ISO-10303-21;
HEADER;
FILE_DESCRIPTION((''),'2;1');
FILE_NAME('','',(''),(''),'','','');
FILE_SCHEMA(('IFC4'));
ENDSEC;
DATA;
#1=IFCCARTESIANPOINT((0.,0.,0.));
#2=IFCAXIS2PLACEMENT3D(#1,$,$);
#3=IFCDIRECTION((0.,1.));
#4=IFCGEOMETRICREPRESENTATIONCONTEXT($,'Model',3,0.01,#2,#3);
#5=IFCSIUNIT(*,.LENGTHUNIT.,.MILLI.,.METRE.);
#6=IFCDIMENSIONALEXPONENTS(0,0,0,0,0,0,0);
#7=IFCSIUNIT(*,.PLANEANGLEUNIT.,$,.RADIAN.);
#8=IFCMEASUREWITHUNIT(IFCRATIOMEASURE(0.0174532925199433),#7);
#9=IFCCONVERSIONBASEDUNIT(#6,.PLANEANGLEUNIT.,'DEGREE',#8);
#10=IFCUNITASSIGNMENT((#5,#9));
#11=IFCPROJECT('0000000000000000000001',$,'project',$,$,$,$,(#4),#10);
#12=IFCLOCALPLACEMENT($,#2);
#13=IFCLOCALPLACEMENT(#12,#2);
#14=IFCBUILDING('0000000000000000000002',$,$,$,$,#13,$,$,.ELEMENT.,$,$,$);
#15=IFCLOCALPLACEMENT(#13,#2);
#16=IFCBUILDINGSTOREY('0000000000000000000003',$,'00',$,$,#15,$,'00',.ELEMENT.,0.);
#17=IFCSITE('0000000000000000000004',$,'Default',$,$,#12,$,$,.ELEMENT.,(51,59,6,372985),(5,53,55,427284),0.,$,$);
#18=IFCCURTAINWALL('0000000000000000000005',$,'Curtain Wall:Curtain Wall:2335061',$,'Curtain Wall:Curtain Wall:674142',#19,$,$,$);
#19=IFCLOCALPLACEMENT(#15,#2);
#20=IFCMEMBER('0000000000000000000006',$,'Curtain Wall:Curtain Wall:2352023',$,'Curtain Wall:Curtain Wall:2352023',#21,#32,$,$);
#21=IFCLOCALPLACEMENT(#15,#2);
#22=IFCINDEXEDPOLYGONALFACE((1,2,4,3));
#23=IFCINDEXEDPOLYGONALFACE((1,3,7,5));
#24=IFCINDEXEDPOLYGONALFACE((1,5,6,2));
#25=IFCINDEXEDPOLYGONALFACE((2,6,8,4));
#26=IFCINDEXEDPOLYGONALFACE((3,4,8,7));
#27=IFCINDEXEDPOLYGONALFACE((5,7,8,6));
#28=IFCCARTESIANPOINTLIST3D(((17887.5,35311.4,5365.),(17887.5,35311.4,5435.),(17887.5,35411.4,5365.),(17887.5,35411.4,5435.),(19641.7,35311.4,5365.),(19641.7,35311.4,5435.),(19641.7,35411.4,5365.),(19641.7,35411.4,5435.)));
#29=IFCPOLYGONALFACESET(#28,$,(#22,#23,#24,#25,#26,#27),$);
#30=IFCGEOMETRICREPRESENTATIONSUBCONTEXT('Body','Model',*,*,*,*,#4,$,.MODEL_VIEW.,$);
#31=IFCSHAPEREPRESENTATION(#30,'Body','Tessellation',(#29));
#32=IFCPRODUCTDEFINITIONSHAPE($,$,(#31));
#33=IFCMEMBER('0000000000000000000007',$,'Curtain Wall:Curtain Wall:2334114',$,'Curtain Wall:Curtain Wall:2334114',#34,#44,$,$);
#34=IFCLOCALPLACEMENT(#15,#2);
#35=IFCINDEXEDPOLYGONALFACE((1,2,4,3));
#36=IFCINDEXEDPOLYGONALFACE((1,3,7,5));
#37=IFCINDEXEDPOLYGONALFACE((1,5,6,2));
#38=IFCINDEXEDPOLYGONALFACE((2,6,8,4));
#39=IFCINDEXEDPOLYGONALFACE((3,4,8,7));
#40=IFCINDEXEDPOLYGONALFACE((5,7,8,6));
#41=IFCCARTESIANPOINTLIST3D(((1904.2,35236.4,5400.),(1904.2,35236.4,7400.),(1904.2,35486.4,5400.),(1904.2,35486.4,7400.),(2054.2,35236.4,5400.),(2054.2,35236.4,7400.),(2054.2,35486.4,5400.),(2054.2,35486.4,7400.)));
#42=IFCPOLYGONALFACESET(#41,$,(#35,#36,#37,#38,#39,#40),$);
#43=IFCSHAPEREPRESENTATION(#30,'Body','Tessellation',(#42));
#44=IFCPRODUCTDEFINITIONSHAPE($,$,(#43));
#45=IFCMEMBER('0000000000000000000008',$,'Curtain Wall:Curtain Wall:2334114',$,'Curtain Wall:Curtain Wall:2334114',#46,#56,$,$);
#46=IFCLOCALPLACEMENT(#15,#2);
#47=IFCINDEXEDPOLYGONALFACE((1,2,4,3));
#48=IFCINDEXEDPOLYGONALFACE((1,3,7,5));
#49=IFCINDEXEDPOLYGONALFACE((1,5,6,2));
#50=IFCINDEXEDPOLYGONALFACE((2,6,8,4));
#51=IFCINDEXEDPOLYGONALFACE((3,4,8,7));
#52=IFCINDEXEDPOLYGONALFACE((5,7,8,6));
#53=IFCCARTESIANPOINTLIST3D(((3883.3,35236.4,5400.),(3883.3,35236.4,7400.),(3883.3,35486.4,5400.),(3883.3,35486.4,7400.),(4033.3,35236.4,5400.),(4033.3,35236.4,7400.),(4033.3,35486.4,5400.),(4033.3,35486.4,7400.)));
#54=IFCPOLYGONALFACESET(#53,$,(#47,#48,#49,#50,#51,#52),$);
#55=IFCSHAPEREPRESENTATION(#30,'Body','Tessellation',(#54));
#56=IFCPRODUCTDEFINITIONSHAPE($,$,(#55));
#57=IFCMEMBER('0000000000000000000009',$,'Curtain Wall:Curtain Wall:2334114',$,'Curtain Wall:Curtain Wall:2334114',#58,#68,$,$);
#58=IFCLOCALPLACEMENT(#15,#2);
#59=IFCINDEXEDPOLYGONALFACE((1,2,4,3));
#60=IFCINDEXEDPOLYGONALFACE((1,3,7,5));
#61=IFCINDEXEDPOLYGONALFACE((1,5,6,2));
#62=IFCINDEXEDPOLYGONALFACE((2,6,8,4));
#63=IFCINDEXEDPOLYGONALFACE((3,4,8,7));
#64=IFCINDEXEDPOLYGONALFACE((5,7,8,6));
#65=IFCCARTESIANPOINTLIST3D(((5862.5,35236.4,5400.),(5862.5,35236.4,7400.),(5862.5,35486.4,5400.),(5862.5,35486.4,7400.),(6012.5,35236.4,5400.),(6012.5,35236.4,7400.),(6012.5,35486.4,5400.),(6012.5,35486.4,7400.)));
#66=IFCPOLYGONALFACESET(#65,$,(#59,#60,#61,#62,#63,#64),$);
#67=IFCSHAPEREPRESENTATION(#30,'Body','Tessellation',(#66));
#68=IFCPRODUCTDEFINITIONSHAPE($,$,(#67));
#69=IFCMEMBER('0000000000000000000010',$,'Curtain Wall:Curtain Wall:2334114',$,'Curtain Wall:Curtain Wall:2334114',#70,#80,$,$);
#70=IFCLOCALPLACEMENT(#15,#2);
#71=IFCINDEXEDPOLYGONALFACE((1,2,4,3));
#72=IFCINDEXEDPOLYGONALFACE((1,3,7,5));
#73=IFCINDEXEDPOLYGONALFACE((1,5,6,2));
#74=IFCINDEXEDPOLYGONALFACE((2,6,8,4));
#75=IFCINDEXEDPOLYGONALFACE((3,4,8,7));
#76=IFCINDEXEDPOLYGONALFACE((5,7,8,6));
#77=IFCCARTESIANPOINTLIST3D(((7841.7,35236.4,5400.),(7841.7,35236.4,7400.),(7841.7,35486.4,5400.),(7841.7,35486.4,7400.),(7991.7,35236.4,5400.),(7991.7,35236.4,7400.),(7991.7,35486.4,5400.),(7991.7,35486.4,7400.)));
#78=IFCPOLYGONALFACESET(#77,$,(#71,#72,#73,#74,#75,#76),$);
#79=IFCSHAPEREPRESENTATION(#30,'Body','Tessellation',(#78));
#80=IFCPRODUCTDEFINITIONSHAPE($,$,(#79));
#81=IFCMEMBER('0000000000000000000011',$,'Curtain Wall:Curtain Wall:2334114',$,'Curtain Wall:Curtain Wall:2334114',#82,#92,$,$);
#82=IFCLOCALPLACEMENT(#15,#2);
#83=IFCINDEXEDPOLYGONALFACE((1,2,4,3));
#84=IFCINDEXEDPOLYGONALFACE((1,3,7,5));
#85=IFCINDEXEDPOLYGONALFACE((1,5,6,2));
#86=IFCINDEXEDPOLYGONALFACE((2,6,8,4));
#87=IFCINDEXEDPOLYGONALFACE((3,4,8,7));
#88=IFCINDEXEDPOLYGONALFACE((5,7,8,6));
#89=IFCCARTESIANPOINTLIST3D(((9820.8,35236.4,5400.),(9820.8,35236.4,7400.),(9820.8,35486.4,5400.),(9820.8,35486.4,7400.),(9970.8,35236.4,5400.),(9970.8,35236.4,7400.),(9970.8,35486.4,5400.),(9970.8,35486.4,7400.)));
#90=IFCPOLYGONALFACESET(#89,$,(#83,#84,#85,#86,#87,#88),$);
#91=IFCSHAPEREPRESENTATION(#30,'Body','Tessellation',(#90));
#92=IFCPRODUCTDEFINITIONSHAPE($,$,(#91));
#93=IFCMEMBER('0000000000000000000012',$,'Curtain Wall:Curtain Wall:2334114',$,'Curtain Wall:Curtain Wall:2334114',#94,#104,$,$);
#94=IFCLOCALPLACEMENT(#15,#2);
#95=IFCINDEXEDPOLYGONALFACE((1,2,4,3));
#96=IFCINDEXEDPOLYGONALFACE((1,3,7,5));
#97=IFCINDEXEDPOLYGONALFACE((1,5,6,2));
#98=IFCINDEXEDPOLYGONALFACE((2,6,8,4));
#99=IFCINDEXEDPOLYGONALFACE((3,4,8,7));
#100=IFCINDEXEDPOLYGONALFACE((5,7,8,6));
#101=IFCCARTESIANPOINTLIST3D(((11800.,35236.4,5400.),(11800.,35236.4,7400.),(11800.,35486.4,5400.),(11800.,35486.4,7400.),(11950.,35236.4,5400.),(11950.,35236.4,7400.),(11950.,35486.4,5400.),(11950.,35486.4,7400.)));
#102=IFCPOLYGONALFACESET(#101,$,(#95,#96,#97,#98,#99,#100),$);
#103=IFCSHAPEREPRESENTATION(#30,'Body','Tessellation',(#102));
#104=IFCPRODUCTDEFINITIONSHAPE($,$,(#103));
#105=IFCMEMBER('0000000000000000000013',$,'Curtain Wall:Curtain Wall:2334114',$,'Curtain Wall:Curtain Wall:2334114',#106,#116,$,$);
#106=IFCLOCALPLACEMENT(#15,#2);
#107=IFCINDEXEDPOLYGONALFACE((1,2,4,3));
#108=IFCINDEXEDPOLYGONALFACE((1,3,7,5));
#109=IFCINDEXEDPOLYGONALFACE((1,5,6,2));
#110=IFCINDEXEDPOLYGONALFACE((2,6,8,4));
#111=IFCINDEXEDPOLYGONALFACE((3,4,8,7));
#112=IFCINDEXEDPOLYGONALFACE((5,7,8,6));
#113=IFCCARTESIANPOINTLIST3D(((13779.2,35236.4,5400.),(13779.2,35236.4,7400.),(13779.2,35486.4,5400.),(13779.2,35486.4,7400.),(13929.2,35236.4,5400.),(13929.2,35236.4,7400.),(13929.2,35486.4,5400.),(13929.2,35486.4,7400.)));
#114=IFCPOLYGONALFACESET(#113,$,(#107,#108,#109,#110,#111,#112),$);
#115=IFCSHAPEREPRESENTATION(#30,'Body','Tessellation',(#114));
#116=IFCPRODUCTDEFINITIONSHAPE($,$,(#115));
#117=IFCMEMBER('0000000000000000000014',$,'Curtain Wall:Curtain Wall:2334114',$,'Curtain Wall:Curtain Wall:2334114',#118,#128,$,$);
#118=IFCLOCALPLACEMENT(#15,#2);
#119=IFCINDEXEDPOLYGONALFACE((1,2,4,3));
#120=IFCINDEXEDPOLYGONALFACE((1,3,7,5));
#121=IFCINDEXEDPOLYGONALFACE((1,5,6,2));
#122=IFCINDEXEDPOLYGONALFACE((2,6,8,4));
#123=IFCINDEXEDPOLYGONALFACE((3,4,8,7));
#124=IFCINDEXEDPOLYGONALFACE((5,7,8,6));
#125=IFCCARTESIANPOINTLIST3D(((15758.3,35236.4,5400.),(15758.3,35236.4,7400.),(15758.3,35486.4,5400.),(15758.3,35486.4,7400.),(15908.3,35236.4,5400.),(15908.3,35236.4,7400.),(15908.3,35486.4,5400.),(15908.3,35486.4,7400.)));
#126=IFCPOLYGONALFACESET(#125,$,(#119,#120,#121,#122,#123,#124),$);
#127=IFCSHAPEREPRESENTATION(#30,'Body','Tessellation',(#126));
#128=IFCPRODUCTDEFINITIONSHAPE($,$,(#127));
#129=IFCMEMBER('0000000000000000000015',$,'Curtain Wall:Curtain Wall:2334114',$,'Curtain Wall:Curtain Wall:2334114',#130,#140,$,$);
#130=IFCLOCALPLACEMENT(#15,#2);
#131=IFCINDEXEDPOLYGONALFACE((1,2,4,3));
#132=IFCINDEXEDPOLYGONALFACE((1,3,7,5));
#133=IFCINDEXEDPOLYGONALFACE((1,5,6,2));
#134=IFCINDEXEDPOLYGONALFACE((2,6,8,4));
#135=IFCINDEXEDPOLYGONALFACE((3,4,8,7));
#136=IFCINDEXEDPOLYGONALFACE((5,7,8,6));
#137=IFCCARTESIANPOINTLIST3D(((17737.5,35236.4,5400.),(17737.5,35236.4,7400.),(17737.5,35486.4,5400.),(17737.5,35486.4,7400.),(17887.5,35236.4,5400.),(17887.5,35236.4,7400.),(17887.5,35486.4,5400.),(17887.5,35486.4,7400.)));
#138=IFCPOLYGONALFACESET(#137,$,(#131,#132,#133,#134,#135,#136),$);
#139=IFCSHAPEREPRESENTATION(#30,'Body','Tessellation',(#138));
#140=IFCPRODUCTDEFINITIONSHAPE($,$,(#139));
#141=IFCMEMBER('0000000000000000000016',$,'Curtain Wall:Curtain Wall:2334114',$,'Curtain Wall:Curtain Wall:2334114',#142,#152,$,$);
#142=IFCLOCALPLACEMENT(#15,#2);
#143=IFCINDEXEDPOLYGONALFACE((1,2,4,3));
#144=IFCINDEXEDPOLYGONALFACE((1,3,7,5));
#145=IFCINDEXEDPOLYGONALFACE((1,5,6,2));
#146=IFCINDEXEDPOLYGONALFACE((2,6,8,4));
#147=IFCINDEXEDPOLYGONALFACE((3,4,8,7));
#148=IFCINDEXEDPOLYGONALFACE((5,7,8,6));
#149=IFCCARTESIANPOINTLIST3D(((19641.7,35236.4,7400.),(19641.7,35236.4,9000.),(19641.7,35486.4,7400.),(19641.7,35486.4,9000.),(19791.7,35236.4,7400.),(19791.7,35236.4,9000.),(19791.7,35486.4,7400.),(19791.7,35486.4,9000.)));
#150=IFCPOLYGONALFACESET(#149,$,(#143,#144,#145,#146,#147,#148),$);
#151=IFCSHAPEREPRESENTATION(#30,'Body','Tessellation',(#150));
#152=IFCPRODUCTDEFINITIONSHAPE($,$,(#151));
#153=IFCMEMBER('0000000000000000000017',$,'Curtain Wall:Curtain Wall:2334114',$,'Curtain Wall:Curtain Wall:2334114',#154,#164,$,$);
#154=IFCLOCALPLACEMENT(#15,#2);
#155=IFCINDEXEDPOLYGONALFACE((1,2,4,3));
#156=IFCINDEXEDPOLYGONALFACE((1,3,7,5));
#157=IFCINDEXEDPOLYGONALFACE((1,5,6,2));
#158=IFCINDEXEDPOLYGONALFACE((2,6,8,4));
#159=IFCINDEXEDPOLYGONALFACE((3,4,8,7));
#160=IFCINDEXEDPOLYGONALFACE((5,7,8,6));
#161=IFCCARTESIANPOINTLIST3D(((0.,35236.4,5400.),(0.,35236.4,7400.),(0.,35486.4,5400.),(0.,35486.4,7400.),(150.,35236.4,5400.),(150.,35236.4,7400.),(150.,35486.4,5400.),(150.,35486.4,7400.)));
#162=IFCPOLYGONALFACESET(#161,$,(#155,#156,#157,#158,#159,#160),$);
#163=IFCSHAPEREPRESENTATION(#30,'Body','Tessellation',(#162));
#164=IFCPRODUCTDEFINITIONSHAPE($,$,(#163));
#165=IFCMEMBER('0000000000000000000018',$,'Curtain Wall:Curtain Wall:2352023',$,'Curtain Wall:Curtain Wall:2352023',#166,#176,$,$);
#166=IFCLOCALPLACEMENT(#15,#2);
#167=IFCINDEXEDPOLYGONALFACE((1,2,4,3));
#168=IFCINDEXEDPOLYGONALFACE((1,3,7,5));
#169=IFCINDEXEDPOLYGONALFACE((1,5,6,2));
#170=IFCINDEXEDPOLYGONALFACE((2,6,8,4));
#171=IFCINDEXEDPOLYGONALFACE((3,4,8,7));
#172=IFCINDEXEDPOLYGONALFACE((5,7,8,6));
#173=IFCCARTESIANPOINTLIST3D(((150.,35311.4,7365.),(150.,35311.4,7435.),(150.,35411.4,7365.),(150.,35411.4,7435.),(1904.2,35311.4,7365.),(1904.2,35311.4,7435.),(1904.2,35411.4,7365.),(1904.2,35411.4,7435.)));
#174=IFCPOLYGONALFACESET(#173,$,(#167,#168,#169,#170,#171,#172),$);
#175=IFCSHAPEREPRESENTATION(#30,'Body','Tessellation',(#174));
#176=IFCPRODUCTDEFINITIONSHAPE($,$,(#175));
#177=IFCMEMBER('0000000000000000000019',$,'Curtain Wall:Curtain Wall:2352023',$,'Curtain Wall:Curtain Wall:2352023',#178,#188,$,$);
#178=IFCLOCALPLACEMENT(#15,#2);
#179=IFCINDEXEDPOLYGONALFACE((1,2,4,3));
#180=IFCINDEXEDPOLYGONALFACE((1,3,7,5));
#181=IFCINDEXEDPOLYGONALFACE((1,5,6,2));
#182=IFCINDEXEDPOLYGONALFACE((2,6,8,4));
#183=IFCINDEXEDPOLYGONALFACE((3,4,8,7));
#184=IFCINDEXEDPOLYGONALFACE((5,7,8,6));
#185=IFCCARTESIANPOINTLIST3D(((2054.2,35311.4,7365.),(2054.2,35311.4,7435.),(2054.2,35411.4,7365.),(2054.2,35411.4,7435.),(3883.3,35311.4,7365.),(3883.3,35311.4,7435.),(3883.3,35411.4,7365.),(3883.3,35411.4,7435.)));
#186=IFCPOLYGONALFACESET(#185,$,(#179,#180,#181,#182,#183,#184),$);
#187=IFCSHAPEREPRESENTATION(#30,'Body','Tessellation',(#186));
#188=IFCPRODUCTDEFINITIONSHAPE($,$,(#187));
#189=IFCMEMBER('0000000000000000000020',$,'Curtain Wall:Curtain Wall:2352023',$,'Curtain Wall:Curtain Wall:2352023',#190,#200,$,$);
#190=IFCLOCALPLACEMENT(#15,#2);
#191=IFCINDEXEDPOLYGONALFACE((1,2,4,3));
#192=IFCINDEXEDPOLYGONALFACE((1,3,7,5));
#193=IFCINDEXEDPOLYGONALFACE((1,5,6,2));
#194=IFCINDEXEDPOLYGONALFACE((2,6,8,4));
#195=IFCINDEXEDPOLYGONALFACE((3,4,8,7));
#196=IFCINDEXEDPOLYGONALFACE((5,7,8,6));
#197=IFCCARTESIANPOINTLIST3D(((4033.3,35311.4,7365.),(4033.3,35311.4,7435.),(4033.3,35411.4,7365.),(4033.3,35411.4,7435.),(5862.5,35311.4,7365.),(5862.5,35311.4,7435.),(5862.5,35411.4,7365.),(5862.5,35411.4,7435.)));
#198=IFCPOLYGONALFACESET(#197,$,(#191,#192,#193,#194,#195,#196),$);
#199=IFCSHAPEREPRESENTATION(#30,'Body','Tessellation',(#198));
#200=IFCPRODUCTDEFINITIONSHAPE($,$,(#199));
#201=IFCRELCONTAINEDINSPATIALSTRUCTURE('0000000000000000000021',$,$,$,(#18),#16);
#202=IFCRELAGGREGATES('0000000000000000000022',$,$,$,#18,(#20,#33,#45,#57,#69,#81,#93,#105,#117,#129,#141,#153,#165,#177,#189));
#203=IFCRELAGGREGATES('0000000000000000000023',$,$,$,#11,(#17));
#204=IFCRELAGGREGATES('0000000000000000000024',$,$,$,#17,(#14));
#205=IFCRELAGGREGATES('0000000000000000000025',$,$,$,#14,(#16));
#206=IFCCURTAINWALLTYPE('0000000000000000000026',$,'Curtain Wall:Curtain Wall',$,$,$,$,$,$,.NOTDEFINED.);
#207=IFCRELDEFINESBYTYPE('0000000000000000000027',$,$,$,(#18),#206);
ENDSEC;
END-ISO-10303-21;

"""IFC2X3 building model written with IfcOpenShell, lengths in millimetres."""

from ifc_helpers import new_model, entity, si_unit, converted_unit, direction, frame, frame_2d, origin, place, context, subcontext, project, spatial, rectangle, extrude, type_object, element, aggregate, save


model = new_model("IFC2X3")

# Units and contexts
model_context = context("Model", 3, precision=0.01, world=origin(), true_north=direction((0.0, 1.0)))
body_context = subcontext(model_context, "Body", "Model", "MODEL_VIEW")
ifc_project = project(units=[si_unit("LENGTHUNIT", "METRE", prefix="MILLI"), converted_unit("PLANEANGLEUNIT", "DEGREE", entity("IfcRatioMeasure", 0.0174532925199433), si_unit("PLANEANGLEUNIT", "RADIAN"), dimensions=[0, 0, 0, 0, 0, 0, 0])], contexts=[model_context])

# Site, building, storey
site_placement = place(None, origin())
site = spatial("IfcSite", under=ifc_project, at=site_placement, Name="Default", CompositionType="ELEMENT", RefLatitude=(51, 59, 6, 372985), RefLongitude=(5, 53, 55, 427284), RefElevation=0.0)
building_placement = place(site_placement, origin())
building = spatial("IfcBuilding", under=site, at=building_placement, CompositionType="ELEMENT")
storey_placement = place(building_placement, origin())
storey = spatial("IfcBuildingStorey", under=building, at=storey_placement, Name="00", LongName="00", CompositionType="ELEMENT", Elevation=0.0)

# Curtain wall, members
curtain_wall_type = type_object("IfcCurtainWallType", Name="Curtain Wall:Curtain Wall", PredefinedType="NOTDEFINED")
curtain_wall_placement = place(storey_placement, origin())
curtain_wall = element("IfcCurtainWall", 1, at=curtain_wall_placement, inside=storey, type_object=curtain_wall_type, Name="Curtain Wall:Curtain Wall:2335061", ObjectType="Curtain Wall:Curtain Wall:674142")
member_1_placement = place(curtain_wall_placement, origin())
member_1 = element("IfcMember", 2, at=member_1_placement, Name="Curtain Wall:Curtain Wall:2352023", ObjectType="Curtain Wall:Curtain Wall:2352023", context=body_context, shape_type="SweptSolid", body=[
    extrude(rectangle(XDim=70.0, YDim=100.0, at=frame_2d((0.0, 0.0), x_axis=(1.0, 0.0))), frame((19641.7, 35361.4, 5400.0), z_axis=(-1.0, 0.0, 0.0), x_axis=(0.0, 0.0, -1.0)), (0.0, 0.0, 1.0), 1754.2),
])
member_2_placement = place(curtain_wall_placement, origin())
member_2 = element("IfcMember", 3, at=member_2_placement, Name="Curtain Wall:Curtain Wall:2334114", ObjectType="Curtain Wall:Curtain Wall:2334114", context=body_context, shape_type="SweptSolid", body=[
    extrude(rectangle(XDim=150.0, YDim=250.0, at=frame_2d((0.0, 0.0), x_axis=(1.0, 0.0))), frame((1979.2, 35361.4, 5400.0), z_axis=(0.0, 0.0, 1.0), x_axis=(-1.0, 0.0, 0.0)), (0.0, 0.0, 1.0), 2000.0),
])
member_3_placement = place(curtain_wall_placement, origin())
member_3 = element("IfcMember", 4, at=member_3_placement, Name="Curtain Wall:Curtain Wall:2334114", ObjectType="Curtain Wall:Curtain Wall:2334114", context=body_context, shape_type="SweptSolid", body=[
    extrude(rectangle(XDim=150.0, YDim=250.0, at=frame_2d((0.0, 0.0), x_axis=(1.0, 0.0))), frame((3958.3, 35361.4, 5400.0), z_axis=(0.0, 0.0, 1.0), x_axis=(-1.0, 0.0, 0.0)), (0.0, 0.0, 1.0), 2000.0),
])
member_4_placement = place(curtain_wall_placement, origin())
member_4 = element("IfcMember", 5, at=member_4_placement, Name="Curtain Wall:Curtain Wall:2334114", ObjectType="Curtain Wall:Curtain Wall:2334114", context=body_context, shape_type="SweptSolid", body=[
    extrude(rectangle(XDim=150.0, YDim=250.0, at=frame_2d((0.0, 0.0), x_axis=(1.0, 0.0))), frame((5937.5, 35361.4, 5400.0), z_axis=(0.0, 0.0, 1.0), x_axis=(-1.0, 0.0, 0.0)), (0.0, 0.0, 1.0), 2000.0),
])
member_5_placement = place(curtain_wall_placement, origin())
member_5 = element("IfcMember", 6, at=member_5_placement, Name="Curtain Wall:Curtain Wall:2334114", ObjectType="Curtain Wall:Curtain Wall:2334114", context=body_context, shape_type="SweptSolid", body=[
    extrude(rectangle(XDim=150.0, YDim=250.0, at=frame_2d((0.0, 0.0), x_axis=(1.0, 0.0))), frame((7916.7, 35361.4, 5400.0), z_axis=(0.0, 0.0, 1.0), x_axis=(-1.0, 0.0, 0.0)), (0.0, 0.0, 1.0), 2000.0),
])
member_6_placement = place(curtain_wall_placement, origin())
member_6 = element("IfcMember", 7, at=member_6_placement, Name="Curtain Wall:Curtain Wall:2334114", ObjectType="Curtain Wall:Curtain Wall:2334114", context=body_context, shape_type="SweptSolid", body=[
    extrude(rectangle(XDim=150.0, YDim=250.0, at=frame_2d((0.0, 0.0), x_axis=(1.0, 0.0))), frame((9895.8, 35361.4, 5400.0), z_axis=(0.0, 0.0, 1.0), x_axis=(-1.0, 0.0, 0.0)), (0.0, 0.0, 1.0), 2000.0),
])
member_7_placement = place(curtain_wall_placement, origin())
member_7 = element("IfcMember", 8, at=member_7_placement, Name="Curtain Wall:Curtain Wall:2334114", ObjectType="Curtain Wall:Curtain Wall:2334114", context=body_context, shape_type="SweptSolid", body=[
    extrude(rectangle(XDim=150.0, YDim=250.0, at=frame_2d((0.0, 0.0), x_axis=(1.0, 0.0))), frame((11875.0, 35361.4, 5400.0), z_axis=(0.0, 0.0, 1.0), x_axis=(-1.0, 0.0, 0.0)), (0.0, 0.0, 1.0), 2000.0),
])
member_8_placement = place(curtain_wall_placement, origin())
member_8 = element("IfcMember", 9, at=member_8_placement, Name="Curtain Wall:Curtain Wall:2334114", ObjectType="Curtain Wall:Curtain Wall:2334114", context=body_context, shape_type="SweptSolid", body=[
    extrude(rectangle(XDim=150.0, YDim=250.0, at=frame_2d((0.0, 0.0), x_axis=(1.0, 0.0))), frame((13854.2, 35361.4, 5400.0), z_axis=(0.0, 0.0, 1.0), x_axis=(-1.0, 0.0, 0.0)), (0.0, 0.0, 1.0), 2000.0),
])
member_9_placement = place(curtain_wall_placement, origin())
member_9 = element("IfcMember", 10, at=member_9_placement, Name="Curtain Wall:Curtain Wall:2334114", ObjectType="Curtain Wall:Curtain Wall:2334114", context=body_context, shape_type="SweptSolid", body=[
    extrude(rectangle(XDim=150.0, YDim=250.0, at=frame_2d((0.0, 0.0), x_axis=(1.0, 0.0))), frame((15833.3, 35361.4, 5400.0), z_axis=(0.0, 0.0, 1.0), x_axis=(-1.0, 0.0, 0.0)), (0.0, 0.0, 1.0), 2000.0),
])
member_10_placement = place(curtain_wall_placement, origin())
member_10 = element("IfcMember", 11, at=member_10_placement, Name="Curtain Wall:Curtain Wall:2334114", ObjectType="Curtain Wall:Curtain Wall:2334114", context=body_context, shape_type="SweptSolid", body=[
    extrude(rectangle(XDim=150.0, YDim=250.0, at=frame_2d((0.0, 0.0), x_axis=(1.0, 0.0))), frame((17812.5, 35361.4, 5400.0), z_axis=(0.0, 0.0, 1.0), x_axis=(-1.0, 0.0, 0.0)), (0.0, 0.0, 1.0), 2000.0),
])
member_11_placement = place(curtain_wall_placement, origin())
member_11 = element("IfcMember", 12, at=member_11_placement, Name="Curtain Wall:Curtain Wall:2334114", ObjectType="Curtain Wall:Curtain Wall:2334114", context=body_context, shape_type="SweptSolid", body=[
    extrude(rectangle(XDim=150.0, YDim=250.0, at=frame_2d((0.0, 0.0), x_axis=(1.0, 0.0))), frame((19716.7, 35361.4, 7400.0), z_axis=(0.0, 0.0, 1.0), x_axis=(-1.0, 0.0, 0.0)), (0.0, 0.0, 1.0), 1600.0),
])
member_12_placement = place(curtain_wall_placement, origin())
member_12 = element("IfcMember", 13, at=member_12_placement, Name="Curtain Wall:Curtain Wall:2334114", ObjectType="Curtain Wall:Curtain Wall:2334114", context=body_context, shape_type="SweptSolid", body=[
    extrude(rectangle(XDim=150.0, YDim=250.0, at=frame_2d((0.0, 0.0), x_axis=(1.0, 0.0))), frame((75.0, 35361.4, 7400.0), z_axis=(0.0, 0.0, -1.0), x_axis=(-1.0, 0.0, 0.0)), (0.0, 0.0, 1.0), 2000.0),
])
member_13_placement = place(curtain_wall_placement, origin())
member_13 = element("IfcMember", 14, at=member_13_placement, Name="Curtain Wall:Curtain Wall:2352023", ObjectType="Curtain Wall:Curtain Wall:2352023", context=body_context, shape_type="SweptSolid", body=[
    extrude(rectangle(XDim=70.0, YDim=100.0, at=frame_2d((0.0, 0.0), x_axis=(1.0, 0.0))), frame((1904.2, 35361.4, 7400.0), z_axis=(-1.0, 0.0, 0.0), x_axis=(0.0, 0.0, -1.0)), (0.0, 0.0, 1.0), 1754.2),
])
member_14_placement = place(curtain_wall_placement, origin())
member_14 = element("IfcMember", 15, at=member_14_placement, Name="Curtain Wall:Curtain Wall:2352023", ObjectType="Curtain Wall:Curtain Wall:2352023", context=body_context, shape_type="SweptSolid", body=[
    extrude(rectangle(XDim=70.0, YDim=100.0, at=frame_2d((0.0, 0.0), x_axis=(1.0, 0.0))), frame((3883.3, 35361.4, 7400.0), z_axis=(-1.0, 0.0, 0.0), x_axis=(0.0, 0.0, -1.0)), (0.0, 0.0, 1.0), 1829.2),
])
member_15_placement = place(curtain_wall_placement, origin())
member_15 = element("IfcMember", 16, at=member_15_placement, Name="Curtain Wall:Curtain Wall:2352023", ObjectType="Curtain Wall:Curtain Wall:2352023", context=body_context, shape_type="SweptSolid", body=[
    extrude(rectangle(XDim=70.0, YDim=100.0, at=frame_2d((0.0, 0.0), x_axis=(1.0, 0.0))), frame((5862.5, 35361.4, 7400.0), z_axis=(-1.0, 0.0, 0.0), x_axis=(0.0, 0.0, -1.0)), (0.0, 0.0, 1.0), 1829.2),
])
aggregate(curtain_wall, [member_1, member_2, member_3, member_4, member_5, member_6, member_7, member_8, member_9, member_10, member_11, member_12, member_13, member_14, member_15])

save(model, "model.ifc")
